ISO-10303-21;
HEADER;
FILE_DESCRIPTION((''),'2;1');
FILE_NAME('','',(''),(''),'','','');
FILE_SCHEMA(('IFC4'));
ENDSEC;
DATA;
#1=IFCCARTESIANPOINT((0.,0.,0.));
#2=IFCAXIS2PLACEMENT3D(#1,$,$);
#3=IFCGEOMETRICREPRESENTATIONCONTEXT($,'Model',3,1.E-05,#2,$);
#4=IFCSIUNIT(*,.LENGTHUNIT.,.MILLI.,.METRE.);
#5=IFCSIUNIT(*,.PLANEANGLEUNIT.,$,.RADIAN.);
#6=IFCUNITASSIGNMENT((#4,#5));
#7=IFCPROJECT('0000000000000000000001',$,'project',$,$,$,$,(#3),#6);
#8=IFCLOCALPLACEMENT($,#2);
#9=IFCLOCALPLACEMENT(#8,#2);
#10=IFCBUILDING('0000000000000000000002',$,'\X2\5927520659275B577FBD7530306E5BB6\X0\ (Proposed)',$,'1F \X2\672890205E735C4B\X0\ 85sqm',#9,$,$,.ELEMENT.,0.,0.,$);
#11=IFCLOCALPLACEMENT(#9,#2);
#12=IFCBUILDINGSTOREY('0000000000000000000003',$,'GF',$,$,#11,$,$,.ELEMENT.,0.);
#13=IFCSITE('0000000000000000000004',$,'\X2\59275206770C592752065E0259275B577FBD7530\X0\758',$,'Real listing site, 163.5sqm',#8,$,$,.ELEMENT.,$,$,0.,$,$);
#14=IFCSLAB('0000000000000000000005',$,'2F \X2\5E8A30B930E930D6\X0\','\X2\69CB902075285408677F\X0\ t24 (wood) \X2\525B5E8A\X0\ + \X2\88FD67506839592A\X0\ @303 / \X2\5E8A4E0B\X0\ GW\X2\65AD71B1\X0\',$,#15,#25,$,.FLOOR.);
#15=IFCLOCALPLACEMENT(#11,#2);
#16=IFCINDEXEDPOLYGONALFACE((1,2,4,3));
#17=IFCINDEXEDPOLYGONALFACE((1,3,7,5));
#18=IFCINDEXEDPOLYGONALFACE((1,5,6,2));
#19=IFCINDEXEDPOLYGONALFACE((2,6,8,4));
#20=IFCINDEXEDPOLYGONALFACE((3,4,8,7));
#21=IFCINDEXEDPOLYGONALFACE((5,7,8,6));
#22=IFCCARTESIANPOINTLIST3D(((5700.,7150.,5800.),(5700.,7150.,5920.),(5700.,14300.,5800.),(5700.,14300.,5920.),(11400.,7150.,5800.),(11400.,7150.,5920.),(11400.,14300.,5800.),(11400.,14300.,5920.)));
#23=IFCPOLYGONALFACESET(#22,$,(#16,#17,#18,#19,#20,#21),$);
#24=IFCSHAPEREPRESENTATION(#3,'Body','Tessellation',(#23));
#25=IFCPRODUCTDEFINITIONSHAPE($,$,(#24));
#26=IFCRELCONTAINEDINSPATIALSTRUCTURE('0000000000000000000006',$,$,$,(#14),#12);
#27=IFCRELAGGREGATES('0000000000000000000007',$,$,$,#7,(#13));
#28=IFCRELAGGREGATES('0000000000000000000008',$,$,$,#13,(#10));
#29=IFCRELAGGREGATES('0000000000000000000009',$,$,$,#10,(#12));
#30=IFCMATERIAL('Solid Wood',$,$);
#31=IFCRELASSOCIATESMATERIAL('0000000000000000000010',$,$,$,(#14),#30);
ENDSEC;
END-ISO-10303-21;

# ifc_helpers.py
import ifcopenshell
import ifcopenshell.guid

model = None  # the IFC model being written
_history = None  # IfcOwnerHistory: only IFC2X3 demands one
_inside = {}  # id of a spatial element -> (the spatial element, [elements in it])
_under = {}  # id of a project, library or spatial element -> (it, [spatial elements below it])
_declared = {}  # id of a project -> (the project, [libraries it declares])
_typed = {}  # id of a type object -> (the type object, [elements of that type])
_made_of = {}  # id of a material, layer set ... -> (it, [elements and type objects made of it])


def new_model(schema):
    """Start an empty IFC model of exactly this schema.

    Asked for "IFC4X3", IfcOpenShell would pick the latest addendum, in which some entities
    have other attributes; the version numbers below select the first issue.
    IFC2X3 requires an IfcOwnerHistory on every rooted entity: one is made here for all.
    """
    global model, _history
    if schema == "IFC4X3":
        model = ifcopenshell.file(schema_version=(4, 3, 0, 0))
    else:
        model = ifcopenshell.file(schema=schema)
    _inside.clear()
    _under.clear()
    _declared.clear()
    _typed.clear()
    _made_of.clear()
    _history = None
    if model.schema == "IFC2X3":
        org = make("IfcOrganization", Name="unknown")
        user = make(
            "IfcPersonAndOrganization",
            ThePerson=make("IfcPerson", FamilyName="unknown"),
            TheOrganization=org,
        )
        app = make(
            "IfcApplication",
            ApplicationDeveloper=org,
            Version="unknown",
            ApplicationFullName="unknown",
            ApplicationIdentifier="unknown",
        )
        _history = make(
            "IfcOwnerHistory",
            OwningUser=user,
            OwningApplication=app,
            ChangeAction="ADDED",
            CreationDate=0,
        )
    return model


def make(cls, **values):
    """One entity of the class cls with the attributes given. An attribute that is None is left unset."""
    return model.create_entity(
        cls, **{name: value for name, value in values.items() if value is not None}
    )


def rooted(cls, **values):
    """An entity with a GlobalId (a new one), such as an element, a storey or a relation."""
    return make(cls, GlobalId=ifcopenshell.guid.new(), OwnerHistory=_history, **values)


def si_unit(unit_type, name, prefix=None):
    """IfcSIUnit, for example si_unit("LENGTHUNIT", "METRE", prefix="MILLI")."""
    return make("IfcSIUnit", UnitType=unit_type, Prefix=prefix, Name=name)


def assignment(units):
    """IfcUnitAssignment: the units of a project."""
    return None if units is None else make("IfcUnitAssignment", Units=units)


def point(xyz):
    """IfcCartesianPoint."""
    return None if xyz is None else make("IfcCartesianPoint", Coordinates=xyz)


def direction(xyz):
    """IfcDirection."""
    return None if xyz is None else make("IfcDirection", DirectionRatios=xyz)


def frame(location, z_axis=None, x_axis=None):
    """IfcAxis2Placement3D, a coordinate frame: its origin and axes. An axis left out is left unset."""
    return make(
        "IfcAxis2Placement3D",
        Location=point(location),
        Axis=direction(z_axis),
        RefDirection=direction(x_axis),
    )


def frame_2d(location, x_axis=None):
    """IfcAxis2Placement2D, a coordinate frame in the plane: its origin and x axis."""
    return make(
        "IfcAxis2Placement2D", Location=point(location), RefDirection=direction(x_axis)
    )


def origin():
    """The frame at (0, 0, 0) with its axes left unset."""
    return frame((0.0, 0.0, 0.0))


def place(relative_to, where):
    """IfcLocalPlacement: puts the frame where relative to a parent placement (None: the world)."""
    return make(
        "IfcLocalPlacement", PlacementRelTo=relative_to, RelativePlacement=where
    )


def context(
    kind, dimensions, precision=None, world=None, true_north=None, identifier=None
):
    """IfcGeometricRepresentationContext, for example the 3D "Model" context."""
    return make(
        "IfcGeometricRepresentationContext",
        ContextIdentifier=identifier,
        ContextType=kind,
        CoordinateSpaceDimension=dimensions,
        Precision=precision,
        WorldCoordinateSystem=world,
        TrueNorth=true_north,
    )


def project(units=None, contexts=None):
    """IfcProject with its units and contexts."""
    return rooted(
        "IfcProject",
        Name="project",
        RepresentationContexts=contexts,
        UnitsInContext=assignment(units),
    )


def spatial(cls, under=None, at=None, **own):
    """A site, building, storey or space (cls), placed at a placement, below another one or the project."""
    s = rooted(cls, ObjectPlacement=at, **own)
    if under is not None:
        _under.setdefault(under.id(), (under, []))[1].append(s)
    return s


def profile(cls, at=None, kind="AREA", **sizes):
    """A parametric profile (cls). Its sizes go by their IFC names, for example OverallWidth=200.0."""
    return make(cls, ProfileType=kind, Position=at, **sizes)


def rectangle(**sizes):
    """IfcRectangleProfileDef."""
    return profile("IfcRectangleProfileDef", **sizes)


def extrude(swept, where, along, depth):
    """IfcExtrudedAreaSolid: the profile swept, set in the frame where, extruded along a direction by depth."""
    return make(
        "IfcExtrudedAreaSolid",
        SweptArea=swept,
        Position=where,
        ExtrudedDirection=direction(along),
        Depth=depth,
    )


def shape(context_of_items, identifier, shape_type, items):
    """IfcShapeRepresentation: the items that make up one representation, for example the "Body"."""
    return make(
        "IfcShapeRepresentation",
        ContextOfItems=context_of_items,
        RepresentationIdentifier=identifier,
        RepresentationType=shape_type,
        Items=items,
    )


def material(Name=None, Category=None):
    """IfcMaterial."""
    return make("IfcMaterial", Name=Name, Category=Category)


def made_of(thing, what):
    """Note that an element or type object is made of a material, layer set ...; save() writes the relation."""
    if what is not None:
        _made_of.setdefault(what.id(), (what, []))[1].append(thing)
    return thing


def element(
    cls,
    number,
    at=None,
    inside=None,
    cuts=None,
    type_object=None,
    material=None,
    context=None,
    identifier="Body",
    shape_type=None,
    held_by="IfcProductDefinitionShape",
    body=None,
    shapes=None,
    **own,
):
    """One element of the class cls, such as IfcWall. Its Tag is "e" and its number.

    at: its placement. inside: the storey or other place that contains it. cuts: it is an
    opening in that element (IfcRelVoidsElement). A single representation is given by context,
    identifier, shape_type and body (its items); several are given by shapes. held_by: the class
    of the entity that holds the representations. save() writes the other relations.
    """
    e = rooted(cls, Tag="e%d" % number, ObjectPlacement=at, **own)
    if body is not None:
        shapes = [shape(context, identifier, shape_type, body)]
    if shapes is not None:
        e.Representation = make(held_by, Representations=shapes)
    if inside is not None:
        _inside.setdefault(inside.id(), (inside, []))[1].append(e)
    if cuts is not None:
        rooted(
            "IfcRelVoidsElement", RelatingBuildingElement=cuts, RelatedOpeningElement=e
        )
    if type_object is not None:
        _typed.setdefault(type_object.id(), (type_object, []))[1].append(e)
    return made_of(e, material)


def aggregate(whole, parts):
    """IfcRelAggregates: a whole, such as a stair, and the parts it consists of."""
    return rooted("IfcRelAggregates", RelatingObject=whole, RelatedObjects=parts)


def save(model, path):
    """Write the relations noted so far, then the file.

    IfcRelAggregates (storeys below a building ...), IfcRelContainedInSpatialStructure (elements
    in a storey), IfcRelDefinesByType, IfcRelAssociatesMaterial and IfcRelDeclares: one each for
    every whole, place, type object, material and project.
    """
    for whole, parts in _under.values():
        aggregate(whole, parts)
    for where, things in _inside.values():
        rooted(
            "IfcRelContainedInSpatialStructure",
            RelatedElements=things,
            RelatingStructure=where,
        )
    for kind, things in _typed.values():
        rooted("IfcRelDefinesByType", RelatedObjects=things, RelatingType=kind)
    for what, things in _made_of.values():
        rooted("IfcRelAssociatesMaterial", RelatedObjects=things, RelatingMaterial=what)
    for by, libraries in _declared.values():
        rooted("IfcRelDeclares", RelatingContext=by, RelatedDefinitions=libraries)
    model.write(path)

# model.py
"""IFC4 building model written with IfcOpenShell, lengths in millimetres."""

from ifc_helpers import new_model, si_unit, frame, frame_2d, origin, place, context, project, spatial, rectangle, extrude, material, element, save


model = new_model("IFC4")

# Units and contexts
model_context = context("Model", 3, precision=1e-05, world=origin())
ifc_project = project(units=[si_unit("LENGTHUNIT", "METRE", prefix="MILLI"), si_unit("PLANEANGLEUNIT", "RADIAN")], contexts=[model_context])

# Site, building, storey
site_placement = place(None, origin())
site = spatial("IfcSite", under=ifc_project, at=site_placement, Name="大分県大分市大字羽田758", ObjectType="Real listing site, 163.5sqm", CompositionType="ELEMENT", RefElevation=0.0)
building_placement = place(site_placement, origin())
building = spatial("IfcBuilding", under=site, at=building_placement, Name="大分大字羽田の家 (Proposed)", ObjectType="1F 木造平屋 85sqm", CompositionType="ELEMENT", ElevationOfRefHeight=0.0, ElevationOfTerrain=0.0)
storey_placement = place(building_placement, origin())
storey = spatial("IfcBuildingStorey", under=building, at=storey_placement, Name="GF", CompositionType="ELEMENT", Elevation=0.0)

# Slab
ifc_material_1 = material(Name="Solid Wood")
slab_placement = place(storey_placement, frame((2850.0, 3575.0, 2900.0)))
element("IfcSlab", 1, at=slab_placement, inside=storey, material=ifc_material_1, Name="2F 床スラブ", Description="構造用合板 t24 (wood) 剛床 + 製材根太 @303 / 床下 GW断熱", PredefinedType="FLOOR", context=model_context, shape_type="SweptSolid", body=[
    extrude(rectangle(XDim=5700.0, YDim=7150.0, at=frame_2d((2850.0, 3575.0))), frame((2850.0, 3575.0, 2900.0)), (0.0, 0.0, 1.0), 120.0),
])

save(model, "model.ifc")
